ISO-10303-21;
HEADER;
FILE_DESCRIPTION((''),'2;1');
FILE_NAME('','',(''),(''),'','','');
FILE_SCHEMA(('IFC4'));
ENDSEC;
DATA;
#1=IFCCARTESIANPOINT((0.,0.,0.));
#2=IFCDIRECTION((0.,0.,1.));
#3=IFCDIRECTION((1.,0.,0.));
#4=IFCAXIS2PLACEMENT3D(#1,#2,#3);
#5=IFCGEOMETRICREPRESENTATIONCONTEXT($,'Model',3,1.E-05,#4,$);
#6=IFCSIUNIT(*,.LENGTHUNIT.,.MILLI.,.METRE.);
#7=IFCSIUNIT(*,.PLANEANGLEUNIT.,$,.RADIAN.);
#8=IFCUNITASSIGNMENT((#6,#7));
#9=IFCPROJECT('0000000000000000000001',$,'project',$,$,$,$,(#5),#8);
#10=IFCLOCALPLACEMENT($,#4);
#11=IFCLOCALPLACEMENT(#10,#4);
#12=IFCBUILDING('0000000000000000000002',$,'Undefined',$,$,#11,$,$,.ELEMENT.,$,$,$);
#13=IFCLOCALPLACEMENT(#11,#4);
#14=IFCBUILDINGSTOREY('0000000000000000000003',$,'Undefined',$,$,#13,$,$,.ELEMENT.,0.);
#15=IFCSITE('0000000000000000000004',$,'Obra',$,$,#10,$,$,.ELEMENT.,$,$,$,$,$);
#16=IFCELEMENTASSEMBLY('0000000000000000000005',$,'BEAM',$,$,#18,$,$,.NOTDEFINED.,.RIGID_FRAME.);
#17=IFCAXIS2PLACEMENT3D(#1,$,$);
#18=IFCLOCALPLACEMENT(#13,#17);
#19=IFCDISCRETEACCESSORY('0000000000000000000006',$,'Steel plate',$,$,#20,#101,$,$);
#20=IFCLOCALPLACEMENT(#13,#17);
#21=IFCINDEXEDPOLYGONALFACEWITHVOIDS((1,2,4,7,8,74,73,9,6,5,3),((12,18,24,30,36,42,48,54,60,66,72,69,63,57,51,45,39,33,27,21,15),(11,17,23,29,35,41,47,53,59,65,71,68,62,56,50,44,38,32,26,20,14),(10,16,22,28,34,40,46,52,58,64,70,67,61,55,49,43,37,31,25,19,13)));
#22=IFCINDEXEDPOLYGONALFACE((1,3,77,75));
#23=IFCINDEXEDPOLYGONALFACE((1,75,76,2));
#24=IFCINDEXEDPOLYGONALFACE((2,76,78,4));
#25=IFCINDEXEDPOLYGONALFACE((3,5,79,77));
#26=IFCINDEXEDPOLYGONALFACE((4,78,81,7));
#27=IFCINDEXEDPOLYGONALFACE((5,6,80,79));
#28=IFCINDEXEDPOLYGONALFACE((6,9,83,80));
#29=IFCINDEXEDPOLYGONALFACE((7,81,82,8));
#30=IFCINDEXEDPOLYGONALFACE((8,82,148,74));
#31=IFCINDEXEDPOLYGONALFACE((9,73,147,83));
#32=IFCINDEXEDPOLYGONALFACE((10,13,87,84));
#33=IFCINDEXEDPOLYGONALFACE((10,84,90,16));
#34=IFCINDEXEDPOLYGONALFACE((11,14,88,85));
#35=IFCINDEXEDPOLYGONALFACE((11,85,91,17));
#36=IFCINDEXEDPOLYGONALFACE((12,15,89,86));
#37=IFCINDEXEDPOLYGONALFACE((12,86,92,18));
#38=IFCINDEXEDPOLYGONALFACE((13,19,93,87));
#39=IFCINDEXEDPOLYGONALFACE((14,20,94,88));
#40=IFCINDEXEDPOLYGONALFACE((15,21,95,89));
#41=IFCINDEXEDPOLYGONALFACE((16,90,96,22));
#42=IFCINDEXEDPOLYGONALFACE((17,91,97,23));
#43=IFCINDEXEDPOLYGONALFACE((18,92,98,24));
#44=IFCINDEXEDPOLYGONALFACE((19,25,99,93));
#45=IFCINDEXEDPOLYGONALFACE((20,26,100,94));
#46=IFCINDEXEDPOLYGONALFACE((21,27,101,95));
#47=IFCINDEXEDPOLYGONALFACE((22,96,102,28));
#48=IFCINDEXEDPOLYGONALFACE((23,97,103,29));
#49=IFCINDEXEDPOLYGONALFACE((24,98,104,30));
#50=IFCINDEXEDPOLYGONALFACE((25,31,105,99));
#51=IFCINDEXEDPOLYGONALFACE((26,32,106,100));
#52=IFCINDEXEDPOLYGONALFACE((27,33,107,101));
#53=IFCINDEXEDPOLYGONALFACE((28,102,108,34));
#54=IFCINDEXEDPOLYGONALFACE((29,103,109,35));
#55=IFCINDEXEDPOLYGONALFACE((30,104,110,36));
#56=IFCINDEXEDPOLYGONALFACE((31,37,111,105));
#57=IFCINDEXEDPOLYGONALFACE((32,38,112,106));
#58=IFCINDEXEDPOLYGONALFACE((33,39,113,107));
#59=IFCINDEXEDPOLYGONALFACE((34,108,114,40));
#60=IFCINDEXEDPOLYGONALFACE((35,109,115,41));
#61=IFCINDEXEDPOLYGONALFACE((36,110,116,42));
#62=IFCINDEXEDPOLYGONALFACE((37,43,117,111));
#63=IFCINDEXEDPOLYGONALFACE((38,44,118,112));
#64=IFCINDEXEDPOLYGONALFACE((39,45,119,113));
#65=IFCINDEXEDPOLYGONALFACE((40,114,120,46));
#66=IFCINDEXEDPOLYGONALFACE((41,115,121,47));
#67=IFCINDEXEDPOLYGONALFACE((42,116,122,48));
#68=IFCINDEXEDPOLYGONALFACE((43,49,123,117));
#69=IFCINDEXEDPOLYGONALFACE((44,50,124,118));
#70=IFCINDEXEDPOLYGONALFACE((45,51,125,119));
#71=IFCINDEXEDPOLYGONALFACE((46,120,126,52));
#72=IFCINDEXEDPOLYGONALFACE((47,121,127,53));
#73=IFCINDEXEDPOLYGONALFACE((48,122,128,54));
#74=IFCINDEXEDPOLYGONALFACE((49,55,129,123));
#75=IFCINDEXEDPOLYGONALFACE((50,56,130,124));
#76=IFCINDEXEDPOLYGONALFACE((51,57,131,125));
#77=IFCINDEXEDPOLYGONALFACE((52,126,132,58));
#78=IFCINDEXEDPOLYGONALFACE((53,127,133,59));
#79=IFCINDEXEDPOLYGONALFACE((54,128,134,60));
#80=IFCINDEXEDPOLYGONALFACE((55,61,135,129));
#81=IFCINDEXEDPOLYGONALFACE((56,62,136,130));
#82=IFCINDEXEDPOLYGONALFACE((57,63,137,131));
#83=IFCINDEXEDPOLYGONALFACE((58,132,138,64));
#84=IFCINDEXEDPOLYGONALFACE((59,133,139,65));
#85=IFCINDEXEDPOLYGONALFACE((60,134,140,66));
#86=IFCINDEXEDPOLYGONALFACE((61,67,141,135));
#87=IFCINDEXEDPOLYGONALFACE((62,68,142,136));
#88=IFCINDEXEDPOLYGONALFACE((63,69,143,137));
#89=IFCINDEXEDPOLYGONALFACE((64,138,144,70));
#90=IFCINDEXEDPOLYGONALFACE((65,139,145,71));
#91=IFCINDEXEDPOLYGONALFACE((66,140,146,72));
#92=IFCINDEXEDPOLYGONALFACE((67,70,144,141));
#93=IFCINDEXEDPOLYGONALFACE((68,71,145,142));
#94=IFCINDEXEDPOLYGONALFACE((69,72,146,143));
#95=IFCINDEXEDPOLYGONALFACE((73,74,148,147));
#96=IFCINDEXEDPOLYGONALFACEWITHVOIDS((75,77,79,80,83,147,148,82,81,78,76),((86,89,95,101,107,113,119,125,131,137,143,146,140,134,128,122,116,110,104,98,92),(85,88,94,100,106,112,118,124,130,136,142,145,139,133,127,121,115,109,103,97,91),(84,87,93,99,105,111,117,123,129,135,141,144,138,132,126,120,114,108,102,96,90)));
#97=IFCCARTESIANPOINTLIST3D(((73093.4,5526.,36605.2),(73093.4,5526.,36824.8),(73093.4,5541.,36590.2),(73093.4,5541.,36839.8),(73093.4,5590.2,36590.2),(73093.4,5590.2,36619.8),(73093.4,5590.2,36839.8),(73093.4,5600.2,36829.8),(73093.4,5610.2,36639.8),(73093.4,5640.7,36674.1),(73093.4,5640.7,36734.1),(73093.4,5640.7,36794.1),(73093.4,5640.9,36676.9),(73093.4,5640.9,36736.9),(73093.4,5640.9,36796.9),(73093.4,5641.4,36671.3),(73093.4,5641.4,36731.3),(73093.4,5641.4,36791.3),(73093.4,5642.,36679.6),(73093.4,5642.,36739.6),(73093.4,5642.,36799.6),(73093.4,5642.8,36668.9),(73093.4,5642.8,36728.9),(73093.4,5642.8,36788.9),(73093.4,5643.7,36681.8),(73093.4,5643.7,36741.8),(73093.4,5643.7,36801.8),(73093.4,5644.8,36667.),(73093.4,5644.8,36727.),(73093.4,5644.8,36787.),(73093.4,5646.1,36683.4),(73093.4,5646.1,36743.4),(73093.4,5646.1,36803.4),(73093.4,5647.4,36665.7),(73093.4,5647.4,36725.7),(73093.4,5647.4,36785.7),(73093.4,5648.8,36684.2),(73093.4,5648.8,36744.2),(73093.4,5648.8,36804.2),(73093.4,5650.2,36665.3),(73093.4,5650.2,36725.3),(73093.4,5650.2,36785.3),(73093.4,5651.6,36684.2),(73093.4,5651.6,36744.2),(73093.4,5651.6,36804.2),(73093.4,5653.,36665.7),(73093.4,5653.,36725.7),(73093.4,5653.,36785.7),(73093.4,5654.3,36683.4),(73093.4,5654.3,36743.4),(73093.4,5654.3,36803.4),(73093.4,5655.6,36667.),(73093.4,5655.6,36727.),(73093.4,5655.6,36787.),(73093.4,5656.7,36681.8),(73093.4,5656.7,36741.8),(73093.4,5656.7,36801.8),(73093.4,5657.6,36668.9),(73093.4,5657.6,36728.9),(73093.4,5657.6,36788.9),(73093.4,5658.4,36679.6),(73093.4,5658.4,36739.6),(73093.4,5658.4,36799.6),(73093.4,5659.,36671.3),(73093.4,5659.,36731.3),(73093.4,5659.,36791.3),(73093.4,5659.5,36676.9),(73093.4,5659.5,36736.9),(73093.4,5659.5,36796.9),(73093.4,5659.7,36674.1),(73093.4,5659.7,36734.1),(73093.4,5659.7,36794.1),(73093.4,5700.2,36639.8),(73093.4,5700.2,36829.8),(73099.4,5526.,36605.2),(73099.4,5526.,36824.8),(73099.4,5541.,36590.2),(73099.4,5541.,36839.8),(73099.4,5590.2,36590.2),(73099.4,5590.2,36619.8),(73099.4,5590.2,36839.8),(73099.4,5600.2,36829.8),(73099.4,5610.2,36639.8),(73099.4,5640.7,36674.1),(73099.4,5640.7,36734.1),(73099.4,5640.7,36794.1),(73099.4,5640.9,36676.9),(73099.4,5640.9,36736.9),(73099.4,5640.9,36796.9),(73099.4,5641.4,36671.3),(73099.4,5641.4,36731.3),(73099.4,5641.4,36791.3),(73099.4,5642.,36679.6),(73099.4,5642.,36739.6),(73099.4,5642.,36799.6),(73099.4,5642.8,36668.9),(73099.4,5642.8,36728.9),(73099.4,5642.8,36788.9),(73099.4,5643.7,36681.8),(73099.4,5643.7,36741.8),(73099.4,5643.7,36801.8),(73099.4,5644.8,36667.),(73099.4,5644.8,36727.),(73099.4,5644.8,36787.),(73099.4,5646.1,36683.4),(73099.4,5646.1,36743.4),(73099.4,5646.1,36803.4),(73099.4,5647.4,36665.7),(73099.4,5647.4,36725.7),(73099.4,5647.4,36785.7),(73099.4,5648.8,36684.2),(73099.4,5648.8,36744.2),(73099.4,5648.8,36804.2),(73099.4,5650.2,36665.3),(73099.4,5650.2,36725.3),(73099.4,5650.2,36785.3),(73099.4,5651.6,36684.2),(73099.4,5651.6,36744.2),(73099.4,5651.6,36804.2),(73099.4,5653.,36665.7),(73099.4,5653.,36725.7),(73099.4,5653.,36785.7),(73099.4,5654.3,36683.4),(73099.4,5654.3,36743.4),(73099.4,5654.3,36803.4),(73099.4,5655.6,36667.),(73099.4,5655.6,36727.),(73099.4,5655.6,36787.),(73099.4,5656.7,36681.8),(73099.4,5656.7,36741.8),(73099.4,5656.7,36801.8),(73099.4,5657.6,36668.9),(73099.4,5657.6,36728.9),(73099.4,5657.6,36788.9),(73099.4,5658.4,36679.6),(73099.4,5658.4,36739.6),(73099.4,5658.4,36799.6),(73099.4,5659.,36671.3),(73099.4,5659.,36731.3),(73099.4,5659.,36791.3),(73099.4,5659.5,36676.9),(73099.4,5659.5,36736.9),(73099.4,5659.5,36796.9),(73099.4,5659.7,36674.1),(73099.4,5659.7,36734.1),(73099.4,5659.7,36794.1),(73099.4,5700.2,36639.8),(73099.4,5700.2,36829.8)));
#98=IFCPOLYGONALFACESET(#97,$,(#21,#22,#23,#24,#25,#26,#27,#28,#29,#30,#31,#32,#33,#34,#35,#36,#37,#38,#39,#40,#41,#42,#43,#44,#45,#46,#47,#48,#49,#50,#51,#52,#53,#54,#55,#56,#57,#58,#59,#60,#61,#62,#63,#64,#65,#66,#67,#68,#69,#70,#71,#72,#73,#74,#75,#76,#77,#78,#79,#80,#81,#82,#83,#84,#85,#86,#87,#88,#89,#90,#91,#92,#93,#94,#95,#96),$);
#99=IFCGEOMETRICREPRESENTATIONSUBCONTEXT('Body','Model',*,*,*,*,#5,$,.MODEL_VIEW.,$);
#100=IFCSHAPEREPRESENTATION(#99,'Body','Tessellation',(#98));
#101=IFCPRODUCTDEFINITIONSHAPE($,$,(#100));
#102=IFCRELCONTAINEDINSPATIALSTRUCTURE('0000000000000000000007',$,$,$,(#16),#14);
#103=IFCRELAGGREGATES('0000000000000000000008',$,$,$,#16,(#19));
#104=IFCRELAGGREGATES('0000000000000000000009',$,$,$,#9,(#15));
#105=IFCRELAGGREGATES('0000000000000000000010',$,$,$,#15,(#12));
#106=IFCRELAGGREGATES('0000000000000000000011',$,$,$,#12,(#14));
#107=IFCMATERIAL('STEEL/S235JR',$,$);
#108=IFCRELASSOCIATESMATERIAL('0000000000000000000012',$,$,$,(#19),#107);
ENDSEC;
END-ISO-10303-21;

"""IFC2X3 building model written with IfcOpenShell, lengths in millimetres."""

from ifc_helpers import new_model, si_unit, frame, origin_with_axes, origin_2d_with_axis, place, context, subcontext, project, spatial, polyline, circle, outline, extrude, source, transform, mapped, material, element, aggregate, save


model = new_model("IFC2X3")

# Units and contexts
model_context = context("Model", 3, precision=1e-05, world=origin_with_axes())
body_context = subcontext(model_context, "Body", "Model", "MODEL_VIEW")
ifc_project = project(units=[si_unit("LENGTHUNIT", "METRE", prefix="MILLI"), si_unit("PLANEANGLEUNIT", "RADIAN")], contexts=[model_context])

# Site, building, storey
site_placement = place(None, origin_with_axes())
site = spatial("IfcSite", under=ifc_project, at=site_placement, Name="Obra", CompositionType="ELEMENT")
building_placement = place(site_placement, origin_with_axes())
building = spatial("IfcBuilding", under=site, at=building_placement, Name="Undefined", CompositionType="ELEMENT")
storey_placement = place(building_placement, origin_with_axes())
storey = spatial("IfcBuildingStorey", under=building, at=storey_placement, Name="Undefined", CompositionType="ELEMENT", Elevation=0.0)

# Shared definitions
ifc_material_1 = material(Name="STEEL/S235JR")

# Element assembly
assembly_1_placement = place(storey_placement, origin_with_axes())
assembly_1 = element("IfcElementAssembly", 1, at=assembly_1_placement, inside=storey, Name="BEAM", AssemblyPlace="NOTDEFINED", PredefinedType="RIGID_FRAME")

# Discrete accessory, opening
shared_shape_1 = source(origin_with_axes(), body_context, "Body", "SweptSolid", [
    extrude(circle(Radius=9.5, at=origin_2d_with_axis()), frame((0.0, 3.0, 0.0), z_axis=(0.0, 1.0, 0.0), x_axis=(1.0, 0.0, 0.0)), (0.0, 0.0, 1.0), 6.2),
])
discrete_accessory_1_placement = place(assembly_1_placement, frame((73096.4, 5526.0, 36605.2), z_axis=(1.0, 0.0, 0.0), x_axis=(0.0, 0.707107, -0.707107)))
discrete_accessory_1 = element("IfcDiscreteAccessory", 2, at=discrete_accessory_1_placement, material=ifc_material_1, Name="Steel plate", context=body_context, shape_type="SweptSolid", body=[
    extrude(outline(polyline([(0.0, 0.0), (21.2, 0.0), (56.0, 34.8), (35.1, 55.7), (35.1, 84.0), (98.7, 147.6), (-35.6, 282.0), (-106.3, 211.3), (-120.5, 211.3), (-120.5, 211.3), (-155.3, 176.5), (-155.3, 155.3), (0.0, 0.0)])), frame((0.0, 0.0, -3.0), z_axis=(0.0, 0.0, 1.0), x_axis=(1.0, 0.0, 0.0)), (0.0, 0.0, 1.0), 6.0),
])
opening_1_placement = place(assembly_1_placement, frame((73102.5, 5600.2, 36829.8), z_axis=(0.0, 1.0, 0.0), x_axis=(0.0, 0.0, -1.0)))
element("IfcOpeningElement", 3, at=opening_1_placement, cuts=discrete_accessory_1, ObjectType="Opening", context=body_context, shape_type="MappedRepresentation", body=[
    mapped(shared_shape_1, transform((35.0, 0.0, 50.0))),
    mapped(shared_shape_1, transform((95.0, 0.0, 50.0))),
    mapped(shared_shape_1, transform((155.0, 0.0, 50.0))),
])
aggregate(assembly_1, [discrete_accessory_1])

save(model, "model.ifc")
